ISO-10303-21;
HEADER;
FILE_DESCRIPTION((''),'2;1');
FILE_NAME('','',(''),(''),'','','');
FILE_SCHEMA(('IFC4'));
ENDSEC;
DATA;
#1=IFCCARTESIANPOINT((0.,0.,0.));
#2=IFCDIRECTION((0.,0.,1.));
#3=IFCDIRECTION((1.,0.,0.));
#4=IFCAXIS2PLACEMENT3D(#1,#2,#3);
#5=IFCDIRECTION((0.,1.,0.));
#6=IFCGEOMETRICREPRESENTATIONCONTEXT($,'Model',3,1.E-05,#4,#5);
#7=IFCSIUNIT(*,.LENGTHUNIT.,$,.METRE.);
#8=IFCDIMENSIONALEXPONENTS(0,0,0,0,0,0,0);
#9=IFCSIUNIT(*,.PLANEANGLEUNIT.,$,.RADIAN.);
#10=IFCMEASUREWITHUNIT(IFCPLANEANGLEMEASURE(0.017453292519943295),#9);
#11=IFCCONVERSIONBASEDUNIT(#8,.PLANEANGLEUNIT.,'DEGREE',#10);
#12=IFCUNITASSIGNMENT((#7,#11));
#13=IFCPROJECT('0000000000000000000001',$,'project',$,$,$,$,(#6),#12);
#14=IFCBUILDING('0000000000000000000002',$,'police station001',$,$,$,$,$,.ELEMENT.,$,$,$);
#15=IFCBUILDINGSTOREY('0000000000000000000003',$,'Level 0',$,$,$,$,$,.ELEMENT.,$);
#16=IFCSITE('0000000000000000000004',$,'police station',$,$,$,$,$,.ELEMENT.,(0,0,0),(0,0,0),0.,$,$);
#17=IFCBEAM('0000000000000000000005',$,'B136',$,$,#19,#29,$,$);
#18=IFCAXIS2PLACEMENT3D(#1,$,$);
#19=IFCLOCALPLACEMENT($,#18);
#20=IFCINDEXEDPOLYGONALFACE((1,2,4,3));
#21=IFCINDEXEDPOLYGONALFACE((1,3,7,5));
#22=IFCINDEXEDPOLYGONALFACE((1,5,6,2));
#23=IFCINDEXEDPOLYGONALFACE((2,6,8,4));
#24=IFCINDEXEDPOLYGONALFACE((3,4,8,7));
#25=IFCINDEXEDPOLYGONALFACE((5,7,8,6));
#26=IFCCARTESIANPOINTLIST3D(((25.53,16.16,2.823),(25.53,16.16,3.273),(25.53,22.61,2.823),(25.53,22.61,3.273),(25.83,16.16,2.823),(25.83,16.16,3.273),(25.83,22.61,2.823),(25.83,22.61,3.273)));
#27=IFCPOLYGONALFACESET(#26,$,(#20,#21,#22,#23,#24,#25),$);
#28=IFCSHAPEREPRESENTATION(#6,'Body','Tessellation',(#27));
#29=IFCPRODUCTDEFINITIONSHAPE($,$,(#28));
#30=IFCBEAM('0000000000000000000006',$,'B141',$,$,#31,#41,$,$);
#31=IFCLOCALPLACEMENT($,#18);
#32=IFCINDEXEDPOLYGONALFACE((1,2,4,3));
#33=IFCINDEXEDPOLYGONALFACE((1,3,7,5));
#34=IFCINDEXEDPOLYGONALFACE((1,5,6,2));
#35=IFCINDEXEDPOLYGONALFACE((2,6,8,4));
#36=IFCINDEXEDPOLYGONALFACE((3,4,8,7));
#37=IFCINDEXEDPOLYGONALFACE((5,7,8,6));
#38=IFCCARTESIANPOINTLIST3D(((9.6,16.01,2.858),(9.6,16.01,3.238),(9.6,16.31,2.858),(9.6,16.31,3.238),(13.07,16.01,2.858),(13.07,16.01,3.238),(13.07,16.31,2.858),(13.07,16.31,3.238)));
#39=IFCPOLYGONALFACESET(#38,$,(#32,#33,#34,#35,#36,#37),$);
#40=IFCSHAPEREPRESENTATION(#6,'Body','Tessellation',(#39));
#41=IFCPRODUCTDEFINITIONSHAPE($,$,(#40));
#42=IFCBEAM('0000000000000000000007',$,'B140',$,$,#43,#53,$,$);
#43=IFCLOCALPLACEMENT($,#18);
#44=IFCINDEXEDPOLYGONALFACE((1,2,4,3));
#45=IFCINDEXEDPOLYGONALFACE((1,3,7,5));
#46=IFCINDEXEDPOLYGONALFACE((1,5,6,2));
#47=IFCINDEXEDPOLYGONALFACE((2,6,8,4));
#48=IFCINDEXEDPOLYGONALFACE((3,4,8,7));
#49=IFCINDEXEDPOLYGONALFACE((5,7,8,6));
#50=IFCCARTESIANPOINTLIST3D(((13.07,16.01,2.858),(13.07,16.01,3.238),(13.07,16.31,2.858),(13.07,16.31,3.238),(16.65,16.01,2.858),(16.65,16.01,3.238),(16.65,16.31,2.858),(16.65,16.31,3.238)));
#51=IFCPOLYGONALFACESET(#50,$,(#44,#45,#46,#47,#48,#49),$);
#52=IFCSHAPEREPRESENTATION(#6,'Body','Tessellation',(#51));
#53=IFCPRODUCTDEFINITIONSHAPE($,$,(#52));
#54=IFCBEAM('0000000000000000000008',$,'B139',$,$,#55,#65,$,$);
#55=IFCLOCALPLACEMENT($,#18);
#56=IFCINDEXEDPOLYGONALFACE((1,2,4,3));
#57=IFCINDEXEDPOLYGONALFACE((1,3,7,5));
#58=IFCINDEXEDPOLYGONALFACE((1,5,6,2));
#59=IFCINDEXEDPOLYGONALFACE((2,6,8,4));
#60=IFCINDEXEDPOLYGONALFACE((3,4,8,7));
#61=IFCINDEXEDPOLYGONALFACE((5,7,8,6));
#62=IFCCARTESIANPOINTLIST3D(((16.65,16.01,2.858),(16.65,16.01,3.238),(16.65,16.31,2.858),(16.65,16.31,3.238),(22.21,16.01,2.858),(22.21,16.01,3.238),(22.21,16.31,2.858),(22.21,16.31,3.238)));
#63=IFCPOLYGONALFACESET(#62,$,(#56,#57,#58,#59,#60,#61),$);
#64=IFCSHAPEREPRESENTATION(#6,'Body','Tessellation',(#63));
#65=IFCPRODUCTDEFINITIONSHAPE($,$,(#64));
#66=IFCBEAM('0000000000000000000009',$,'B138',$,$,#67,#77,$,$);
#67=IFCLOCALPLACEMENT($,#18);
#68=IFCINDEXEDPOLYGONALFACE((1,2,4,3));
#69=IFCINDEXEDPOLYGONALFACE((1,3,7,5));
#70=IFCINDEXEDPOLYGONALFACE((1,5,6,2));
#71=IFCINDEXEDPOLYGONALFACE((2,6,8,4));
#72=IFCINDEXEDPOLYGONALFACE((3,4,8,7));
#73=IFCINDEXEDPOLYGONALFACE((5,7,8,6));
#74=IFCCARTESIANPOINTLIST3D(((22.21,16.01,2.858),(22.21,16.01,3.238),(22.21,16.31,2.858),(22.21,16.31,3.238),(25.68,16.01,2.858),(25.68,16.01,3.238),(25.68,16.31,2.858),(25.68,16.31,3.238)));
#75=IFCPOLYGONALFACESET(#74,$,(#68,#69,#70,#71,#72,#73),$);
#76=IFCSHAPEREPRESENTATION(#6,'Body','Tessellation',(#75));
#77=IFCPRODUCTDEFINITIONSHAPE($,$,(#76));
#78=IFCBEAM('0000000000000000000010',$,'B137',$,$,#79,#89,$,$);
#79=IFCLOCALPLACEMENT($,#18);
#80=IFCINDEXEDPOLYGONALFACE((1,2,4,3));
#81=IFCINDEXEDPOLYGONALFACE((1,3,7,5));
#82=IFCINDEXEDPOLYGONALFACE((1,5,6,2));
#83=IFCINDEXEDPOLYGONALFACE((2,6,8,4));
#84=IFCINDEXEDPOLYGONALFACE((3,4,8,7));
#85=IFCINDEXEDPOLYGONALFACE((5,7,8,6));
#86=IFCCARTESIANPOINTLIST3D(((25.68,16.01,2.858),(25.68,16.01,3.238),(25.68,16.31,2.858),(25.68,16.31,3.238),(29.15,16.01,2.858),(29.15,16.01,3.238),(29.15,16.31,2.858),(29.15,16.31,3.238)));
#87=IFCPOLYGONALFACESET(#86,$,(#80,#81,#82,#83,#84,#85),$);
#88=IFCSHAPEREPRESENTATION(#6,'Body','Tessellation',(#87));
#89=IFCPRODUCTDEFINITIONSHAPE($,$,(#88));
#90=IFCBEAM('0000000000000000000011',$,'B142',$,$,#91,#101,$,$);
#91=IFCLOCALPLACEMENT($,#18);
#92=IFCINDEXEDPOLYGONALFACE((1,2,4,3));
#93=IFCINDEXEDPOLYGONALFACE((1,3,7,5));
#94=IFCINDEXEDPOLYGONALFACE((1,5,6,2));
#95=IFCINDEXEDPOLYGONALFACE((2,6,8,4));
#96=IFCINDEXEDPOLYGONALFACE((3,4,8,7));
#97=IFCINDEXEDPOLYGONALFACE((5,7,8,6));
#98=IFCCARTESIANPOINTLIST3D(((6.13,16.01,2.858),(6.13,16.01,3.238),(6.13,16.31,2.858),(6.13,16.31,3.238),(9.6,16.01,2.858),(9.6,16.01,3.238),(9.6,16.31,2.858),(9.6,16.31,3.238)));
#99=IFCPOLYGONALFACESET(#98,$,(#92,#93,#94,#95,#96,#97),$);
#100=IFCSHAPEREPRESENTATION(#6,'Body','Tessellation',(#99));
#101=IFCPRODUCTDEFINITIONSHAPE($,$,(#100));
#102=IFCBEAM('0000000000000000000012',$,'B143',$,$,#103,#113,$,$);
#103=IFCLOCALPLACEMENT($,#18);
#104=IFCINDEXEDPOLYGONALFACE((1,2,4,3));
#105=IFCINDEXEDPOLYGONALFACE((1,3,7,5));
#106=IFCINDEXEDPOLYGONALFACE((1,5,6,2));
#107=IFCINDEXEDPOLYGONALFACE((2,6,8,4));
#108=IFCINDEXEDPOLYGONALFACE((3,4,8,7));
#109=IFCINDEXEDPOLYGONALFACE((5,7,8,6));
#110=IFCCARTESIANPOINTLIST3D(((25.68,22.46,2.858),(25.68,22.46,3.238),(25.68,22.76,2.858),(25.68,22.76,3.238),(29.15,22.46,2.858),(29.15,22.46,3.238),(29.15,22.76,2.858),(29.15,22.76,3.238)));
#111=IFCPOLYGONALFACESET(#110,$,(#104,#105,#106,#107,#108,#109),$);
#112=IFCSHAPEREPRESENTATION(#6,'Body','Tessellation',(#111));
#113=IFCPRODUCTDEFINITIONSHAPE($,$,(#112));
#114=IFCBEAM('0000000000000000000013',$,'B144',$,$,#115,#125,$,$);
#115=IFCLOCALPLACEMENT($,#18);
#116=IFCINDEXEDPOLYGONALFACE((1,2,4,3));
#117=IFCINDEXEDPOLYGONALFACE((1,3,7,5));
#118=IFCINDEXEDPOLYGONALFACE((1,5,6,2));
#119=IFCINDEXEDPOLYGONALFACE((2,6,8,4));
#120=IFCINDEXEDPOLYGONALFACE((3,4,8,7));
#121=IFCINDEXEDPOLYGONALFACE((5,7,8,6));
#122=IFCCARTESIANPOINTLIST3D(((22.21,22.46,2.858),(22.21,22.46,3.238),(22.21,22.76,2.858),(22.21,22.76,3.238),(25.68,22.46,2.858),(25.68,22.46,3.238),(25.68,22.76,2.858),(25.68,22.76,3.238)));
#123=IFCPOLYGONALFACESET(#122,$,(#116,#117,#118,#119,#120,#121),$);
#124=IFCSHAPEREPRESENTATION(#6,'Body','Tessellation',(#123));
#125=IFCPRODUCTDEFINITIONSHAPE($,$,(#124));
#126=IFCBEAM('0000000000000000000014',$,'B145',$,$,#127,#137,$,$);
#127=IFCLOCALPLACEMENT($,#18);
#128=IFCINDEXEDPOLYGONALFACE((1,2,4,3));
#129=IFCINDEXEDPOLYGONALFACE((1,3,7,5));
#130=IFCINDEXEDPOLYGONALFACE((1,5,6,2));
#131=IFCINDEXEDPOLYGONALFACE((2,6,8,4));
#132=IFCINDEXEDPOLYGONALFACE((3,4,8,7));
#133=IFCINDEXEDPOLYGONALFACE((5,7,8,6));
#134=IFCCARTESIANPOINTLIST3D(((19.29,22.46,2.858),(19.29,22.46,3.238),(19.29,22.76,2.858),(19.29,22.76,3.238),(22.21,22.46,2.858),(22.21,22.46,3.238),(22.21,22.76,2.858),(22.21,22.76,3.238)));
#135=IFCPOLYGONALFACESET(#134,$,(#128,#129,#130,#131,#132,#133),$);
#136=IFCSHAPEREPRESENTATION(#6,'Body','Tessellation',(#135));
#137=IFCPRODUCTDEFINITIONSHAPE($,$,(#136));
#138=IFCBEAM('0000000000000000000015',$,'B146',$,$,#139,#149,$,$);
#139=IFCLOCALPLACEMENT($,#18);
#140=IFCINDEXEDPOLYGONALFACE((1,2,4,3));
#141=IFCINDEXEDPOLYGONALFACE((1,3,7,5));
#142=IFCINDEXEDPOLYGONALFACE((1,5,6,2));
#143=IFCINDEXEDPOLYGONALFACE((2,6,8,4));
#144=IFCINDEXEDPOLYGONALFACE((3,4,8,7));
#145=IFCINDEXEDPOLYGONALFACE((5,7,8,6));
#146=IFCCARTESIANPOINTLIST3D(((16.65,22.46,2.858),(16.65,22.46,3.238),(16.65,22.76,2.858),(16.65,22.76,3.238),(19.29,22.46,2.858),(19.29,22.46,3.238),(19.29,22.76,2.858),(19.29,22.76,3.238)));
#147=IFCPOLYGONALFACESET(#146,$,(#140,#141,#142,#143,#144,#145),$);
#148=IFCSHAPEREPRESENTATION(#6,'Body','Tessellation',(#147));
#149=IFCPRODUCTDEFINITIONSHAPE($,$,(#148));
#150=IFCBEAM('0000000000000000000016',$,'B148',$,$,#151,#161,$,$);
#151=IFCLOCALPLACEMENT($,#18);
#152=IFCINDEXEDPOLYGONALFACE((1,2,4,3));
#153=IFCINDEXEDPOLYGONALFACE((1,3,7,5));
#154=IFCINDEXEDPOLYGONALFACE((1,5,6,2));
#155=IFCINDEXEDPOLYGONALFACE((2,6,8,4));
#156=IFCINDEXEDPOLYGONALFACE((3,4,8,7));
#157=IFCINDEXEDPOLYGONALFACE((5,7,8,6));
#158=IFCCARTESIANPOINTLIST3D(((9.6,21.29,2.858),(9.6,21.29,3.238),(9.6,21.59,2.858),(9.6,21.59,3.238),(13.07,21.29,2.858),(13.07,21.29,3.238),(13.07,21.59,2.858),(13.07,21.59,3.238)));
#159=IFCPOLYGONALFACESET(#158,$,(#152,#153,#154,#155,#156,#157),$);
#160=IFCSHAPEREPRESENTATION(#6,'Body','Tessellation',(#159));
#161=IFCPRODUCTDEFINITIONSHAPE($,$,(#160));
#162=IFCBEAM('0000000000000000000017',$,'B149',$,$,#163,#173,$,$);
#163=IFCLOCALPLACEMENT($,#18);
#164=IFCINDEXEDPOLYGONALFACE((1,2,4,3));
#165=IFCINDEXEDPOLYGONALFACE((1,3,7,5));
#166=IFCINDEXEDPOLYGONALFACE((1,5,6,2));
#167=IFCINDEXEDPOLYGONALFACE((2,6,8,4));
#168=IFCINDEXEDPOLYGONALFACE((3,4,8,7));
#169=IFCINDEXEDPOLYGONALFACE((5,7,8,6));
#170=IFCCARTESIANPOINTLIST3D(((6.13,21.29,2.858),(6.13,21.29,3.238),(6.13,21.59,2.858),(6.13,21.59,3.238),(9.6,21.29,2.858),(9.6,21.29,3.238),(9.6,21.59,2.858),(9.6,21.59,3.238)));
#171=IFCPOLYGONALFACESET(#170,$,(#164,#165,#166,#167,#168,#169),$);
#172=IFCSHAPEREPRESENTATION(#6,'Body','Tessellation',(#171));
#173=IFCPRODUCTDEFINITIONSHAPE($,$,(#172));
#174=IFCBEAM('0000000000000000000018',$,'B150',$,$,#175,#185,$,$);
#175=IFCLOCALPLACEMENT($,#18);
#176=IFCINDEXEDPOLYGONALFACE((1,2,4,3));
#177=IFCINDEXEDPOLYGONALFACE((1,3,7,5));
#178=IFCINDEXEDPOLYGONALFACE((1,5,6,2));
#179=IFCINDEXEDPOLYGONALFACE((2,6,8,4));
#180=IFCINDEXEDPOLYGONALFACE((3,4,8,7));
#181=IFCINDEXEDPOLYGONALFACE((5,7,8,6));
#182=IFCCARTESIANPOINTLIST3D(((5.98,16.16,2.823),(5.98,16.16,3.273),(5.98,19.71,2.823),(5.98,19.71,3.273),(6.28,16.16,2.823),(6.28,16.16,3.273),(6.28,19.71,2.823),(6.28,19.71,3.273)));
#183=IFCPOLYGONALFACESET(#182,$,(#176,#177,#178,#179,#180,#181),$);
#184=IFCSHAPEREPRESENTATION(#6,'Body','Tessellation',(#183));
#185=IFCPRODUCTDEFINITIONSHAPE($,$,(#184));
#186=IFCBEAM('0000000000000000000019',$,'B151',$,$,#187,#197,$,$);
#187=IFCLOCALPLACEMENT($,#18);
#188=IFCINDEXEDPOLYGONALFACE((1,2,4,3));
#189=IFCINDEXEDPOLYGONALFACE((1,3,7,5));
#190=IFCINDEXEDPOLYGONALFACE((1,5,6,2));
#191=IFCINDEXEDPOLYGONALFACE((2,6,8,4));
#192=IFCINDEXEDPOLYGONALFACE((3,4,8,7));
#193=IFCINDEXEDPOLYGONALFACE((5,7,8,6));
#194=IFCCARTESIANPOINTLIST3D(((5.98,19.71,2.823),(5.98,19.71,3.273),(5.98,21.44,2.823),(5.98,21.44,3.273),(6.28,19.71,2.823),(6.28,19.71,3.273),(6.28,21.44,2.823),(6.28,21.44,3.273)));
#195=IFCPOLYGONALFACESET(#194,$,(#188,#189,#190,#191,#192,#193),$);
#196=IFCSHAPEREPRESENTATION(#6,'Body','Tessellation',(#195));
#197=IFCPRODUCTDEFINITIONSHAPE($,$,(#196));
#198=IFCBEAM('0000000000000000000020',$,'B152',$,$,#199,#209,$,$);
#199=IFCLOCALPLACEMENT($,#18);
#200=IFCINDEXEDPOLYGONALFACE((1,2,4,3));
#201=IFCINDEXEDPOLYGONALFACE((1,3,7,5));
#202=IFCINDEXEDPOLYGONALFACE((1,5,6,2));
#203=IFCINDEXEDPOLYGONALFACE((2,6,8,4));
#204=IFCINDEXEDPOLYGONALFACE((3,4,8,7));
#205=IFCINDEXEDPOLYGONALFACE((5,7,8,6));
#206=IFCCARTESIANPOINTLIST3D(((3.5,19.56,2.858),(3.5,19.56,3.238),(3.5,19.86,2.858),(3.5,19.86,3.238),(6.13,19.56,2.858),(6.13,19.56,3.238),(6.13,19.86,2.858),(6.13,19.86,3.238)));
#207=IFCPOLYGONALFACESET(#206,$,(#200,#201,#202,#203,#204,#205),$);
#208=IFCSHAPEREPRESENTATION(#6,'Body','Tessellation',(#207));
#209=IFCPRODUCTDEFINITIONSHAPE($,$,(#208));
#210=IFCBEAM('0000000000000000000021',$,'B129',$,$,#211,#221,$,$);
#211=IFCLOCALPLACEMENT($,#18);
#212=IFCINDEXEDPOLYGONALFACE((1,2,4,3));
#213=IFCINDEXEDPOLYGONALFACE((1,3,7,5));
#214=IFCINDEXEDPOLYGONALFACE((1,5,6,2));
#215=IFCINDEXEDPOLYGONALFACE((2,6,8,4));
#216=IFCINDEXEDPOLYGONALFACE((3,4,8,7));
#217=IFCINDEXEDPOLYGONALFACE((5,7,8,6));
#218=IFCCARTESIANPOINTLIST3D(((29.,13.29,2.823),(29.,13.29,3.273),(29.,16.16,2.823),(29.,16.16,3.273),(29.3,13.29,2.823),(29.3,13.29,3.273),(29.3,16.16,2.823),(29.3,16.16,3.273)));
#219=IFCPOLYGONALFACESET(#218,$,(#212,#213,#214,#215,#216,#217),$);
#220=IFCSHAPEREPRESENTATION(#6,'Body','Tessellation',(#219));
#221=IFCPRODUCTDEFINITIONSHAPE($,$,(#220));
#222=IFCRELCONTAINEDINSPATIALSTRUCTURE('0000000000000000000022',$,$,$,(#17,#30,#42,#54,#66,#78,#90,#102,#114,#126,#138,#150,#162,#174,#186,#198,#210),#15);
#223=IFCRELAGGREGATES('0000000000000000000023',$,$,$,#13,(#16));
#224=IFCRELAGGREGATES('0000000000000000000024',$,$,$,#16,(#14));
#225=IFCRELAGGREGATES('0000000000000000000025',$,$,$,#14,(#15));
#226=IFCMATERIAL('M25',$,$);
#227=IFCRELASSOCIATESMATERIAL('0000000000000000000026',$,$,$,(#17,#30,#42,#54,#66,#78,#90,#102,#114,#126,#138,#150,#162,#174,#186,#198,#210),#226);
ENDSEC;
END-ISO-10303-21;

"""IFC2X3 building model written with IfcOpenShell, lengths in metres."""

from ifc_helpers import new_model, entity, si_unit, converted_unit, direction, frame, frame_2d, origin_with_axes, place, context, project, spatial, rectangle, extrude, material, element, save


model = new_model("IFC2X3")

# Units and contexts
model_context = context("Model", 3, precision=1e-05, world=origin_with_axes(), true_north=direction((0.0, 1.0, 0.0)))
ifc_project = project(units=[si_unit("LENGTHUNIT", "METRE"), converted_unit("PLANEANGLEUNIT", "DEGREE", entity("IfcPlaneAngleMeasure", 0.017453292519943295), si_unit("PLANEANGLEUNIT", "RADIAN"), dimensions=[0, 0, 0, 0, 0, 0, 0])], contexts=[model_context])

# Site, building, storey
site = spatial("IfcSite", under=ifc_project, Name="police station", CompositionType="ELEMENT", RefLatitude=(0, 0, 0), RefLongitude=(0, 0, 0), RefElevation=0.0)
building = spatial("IfcBuilding", under=site, Name="police station001", CompositionType="ELEMENT")
storey = spatial("IfcBuildingStorey", under=building, Name="Level 0", CompositionType="ELEMENT")

# Beams
ifc_material = material(Name="M25")
placement = place(None, origin_with_axes())
element("IfcBeam", 1, at=placement, inside=storey, material=ifc_material, Name="B136", context=model_context, shape_type="SweptSolid", body=[
    extrude(rectangle(XDim=0.3, YDim=0.45, at=frame_2d((0.0, 0.0), x_axis=(0.0, 1.0, 0.0))), frame((25.68, 22.61, 3.048), z_axis=(0.0, -1.0, 0.0), x_axis=(0.0, 0.0, -1.0)), (0.0, 0.0, 1.0), 6.45),
])
element("IfcBeam", 2, at=placement, inside=storey, material=ifc_material, Name="B141", context=model_context, shape_type="SweptSolid", body=[
    extrude(rectangle(XDim=0.3, YDim=0.38, at=frame_2d((0.0, 0.0), x_axis=(0.0, 1.0, 0.0))), frame((13.07, 16.16, 3.048), z_axis=(-1.0, 0.0, 0.0), x_axis=(0.0, 0.0, -1.0)), (0.0, 0.0, 1.0), 3.47),
])
element("IfcBeam", 3, at=placement, inside=storey, material=ifc_material, Name="B140", context=model_context, shape_type="SweptSolid", body=[
    extrude(rectangle(XDim=0.3, YDim=0.38, at=frame_2d((0.0, 0.0), x_axis=(0.0, 1.0, 0.0))), frame((16.65, 16.16, 3.048), z_axis=(-1.0, 0.0, 0.0), x_axis=(0.0, 0.0, -1.0)), (0.0, 0.0, 1.0), 3.58),
])
element("IfcBeam", 4, at=placement, inside=storey, material=ifc_material, Name="B139", context=model_context, shape_type="SweptSolid", body=[
    extrude(rectangle(XDim=0.3, YDim=0.38, at=frame_2d((0.0, 0.0), x_axis=(0.0, 1.0, 0.0))), frame((22.21, 16.16, 3.048), z_axis=(-1.0, 0.0, 0.0), x_axis=(0.0, 0.0, -1.0)), (0.0, 0.0, 1.0), 5.56),
])
element("IfcBeam", 5, at=placement, inside=storey, material=ifc_material, Name="B138", context=model_context, shape_type="SweptSolid", body=[
    extrude(rectangle(XDim=0.3, YDim=0.38, at=frame_2d((0.0, 0.0), x_axis=(0.0, 1.0, 0.0))), frame((22.21, 16.16, 3.048), z_axis=(1.0, 0.0, 0.0), x_axis=(0.0, 0.0, -1.0)), (0.0, 0.0, 1.0), 3.47),
])
element("IfcBeam", 6, at=placement, inside=storey, material=ifc_material, Name="B137", context=model_context, shape_type="SweptSolid", body=[
    extrude(rectangle(XDim=0.3, YDim=0.38, at=frame_2d((0.0, 0.0), x_axis=(0.0, 1.0, 0.0))), frame((25.68, 16.16, 3.048), z_axis=(1.0, 0.0, 0.0), x_axis=(0.0, 0.0, -1.0)), (0.0, 0.0, 1.0), 3.47),
])
element("IfcBeam", 7, at=placement, inside=storey, material=ifc_material, Name="B142", context=model_context, shape_type="SweptSolid", body=[
    extrude(rectangle(XDim=0.3, YDim=0.38, at=frame_2d((0.0, 0.0), x_axis=(0.0, 1.0, 0.0))), frame((9.6, 16.16, 3.048), z_axis=(-1.0, 0.0, 0.0), x_axis=(0.0, 0.0, -1.0)), (0.0, 0.0, 1.0), 3.47),
])
element("IfcBeam", 8, at=placement, inside=storey, material=ifc_material, Name="B143", context=model_context, shape_type="SweptSolid", body=[
    extrude(rectangle(XDim=0.3, YDim=0.38, at=frame_2d((0.0, 0.0), x_axis=(0.0, 1.0, 0.0))), frame((29.15, 22.61, 3.048), z_axis=(-1.0, 0.0, 0.0), x_axis=(0.0, 0.0, -1.0)), (0.0, 0.0, 1.0), 3.47),
])
element("IfcBeam", 9, at=placement, inside=storey, material=ifc_material, Name="B144", context=model_context, shape_type="SweptSolid", body=[
    extrude(rectangle(XDim=0.3, YDim=0.38, at=frame_2d((0.0, 0.0), x_axis=(0.0, 1.0, 0.0))), frame((25.68, 22.61, 3.048), z_axis=(-1.0, 0.0, 0.0), x_axis=(0.0, 0.0, -1.0)), (0.0, 0.0, 1.0), 3.47),
])
element("IfcBeam", 10, at=placement, inside=storey, material=ifc_material, Name="B145", context=model_context, shape_type="SweptSolid", body=[
    extrude(rectangle(XDim=0.3, YDim=0.38, at=frame_2d((0.0, 0.0), x_axis=(0.0, 1.0, 0.0))), frame((22.21, 22.61, 3.048), z_axis=(-1.0, 0.0, 0.0), x_axis=(0.0, 0.0, -1.0)), (0.0, 0.0, 1.0), 2.92),
])
element("IfcBeam", 11, at=placement, inside=storey, material=ifc_material, Name="B146", context=model_context, shape_type="SweptSolid", body=[
    extrude(rectangle(XDim=0.3, YDim=0.38, at=frame_2d((0.0, 0.0), x_axis=(0.0, 1.0, 0.0))), frame((19.29, 22.61, 3.048), z_axis=(-1.0, 0.0, 0.0), x_axis=(0.0, 0.0, -1.0)), (0.0, 0.0, 1.0), 2.64),
])
element("IfcBeam", 12, at=placement, inside=storey, material=ifc_material, Name="B148", context=model_context, shape_type="SweptSolid", body=[
    extrude(rectangle(XDim=0.3, YDim=0.38, at=frame_2d((0.0, 0.0), x_axis=(0.0, 1.0, 0.0))), frame((13.07, 21.44, 3.048), z_axis=(-1.0, 0.0, 0.0), x_axis=(0.0, 0.0, -1.0)), (0.0, 0.0, 1.0), 3.47),
])
element("IfcBeam", 13, at=placement, inside=storey, material=ifc_material, Name="B149", context=model_context, shape_type="SweptSolid", body=[
    extrude(rectangle(XDim=0.3, YDim=0.38, at=frame_2d((0.0, 0.0), x_axis=(0.0, 1.0, 0.0))), frame((9.6, 21.44, 3.048), z_axis=(-1.0, 0.0, 0.0), x_axis=(0.0, 0.0, -1.0)), (0.0, 0.0, 1.0), 3.47),
])
element("IfcBeam", 14, at=placement, inside=storey, material=ifc_material, Name="B150", context=model_context, shape_type="SweptSolid", body=[
    extrude(rectangle(XDim=0.3, YDim=0.45, at=frame_2d((0.0, 0.0), x_axis=(0.0, 1.0, 0.0))), frame((6.13, 16.16, 3.048), z_axis=(0.0, 1.0, 0.0), x_axis=(0.0, 0.0, -1.0)), (0.0, 0.0, 1.0), 3.55),
])
element("IfcBeam", 15, at=placement, inside=storey, material=ifc_material, Name="B151", context=model_context, shape_type="SweptSolid", body=[
    extrude(rectangle(XDim=0.3, YDim=0.45, at=frame_2d((0.0, 0.0), x_axis=(0.0, 1.0, 0.0))), frame((6.13, 19.71, 3.048), z_axis=(0.0, 1.0, 0.0), x_axis=(0.0, 0.0, -1.0)), (0.0, 0.0, 1.0), 1.73),
])
element("IfcBeam", 16, at=placement, inside=storey, material=ifc_material, Name="B152", context=model_context, shape_type="SweptSolid", body=[
    extrude(rectangle(XDim=0.3, YDim=0.38, at=frame_2d((0.0, 0.0), x_axis=(0.0, 1.0, 0.0))), frame((3.5, 19.71, 3.048), z_axis=(1.0, 0.0, 0.0), x_axis=(0.0, 0.0, -1.0)), (0.0, 0.0, 1.0), 2.63),
])
element("IfcBeam", 17, at=placement, inside=storey, material=ifc_material, Name="B129", context=model_context, shape_type="SweptSolid", body=[
    extrude(rectangle(XDim=0.3, YDim=0.45, at=frame_2d((0.0, 0.0), x_axis=(0.0, 1.0, 0.0))), frame((29.15, 13.29, 3.048), z_axis=(0.0, 1.0, 0.0), x_axis=(0.0, 0.0, -1.0)), (0.0, 0.0, 1.0), 2.87),
])

save(model, "model.ifc")
